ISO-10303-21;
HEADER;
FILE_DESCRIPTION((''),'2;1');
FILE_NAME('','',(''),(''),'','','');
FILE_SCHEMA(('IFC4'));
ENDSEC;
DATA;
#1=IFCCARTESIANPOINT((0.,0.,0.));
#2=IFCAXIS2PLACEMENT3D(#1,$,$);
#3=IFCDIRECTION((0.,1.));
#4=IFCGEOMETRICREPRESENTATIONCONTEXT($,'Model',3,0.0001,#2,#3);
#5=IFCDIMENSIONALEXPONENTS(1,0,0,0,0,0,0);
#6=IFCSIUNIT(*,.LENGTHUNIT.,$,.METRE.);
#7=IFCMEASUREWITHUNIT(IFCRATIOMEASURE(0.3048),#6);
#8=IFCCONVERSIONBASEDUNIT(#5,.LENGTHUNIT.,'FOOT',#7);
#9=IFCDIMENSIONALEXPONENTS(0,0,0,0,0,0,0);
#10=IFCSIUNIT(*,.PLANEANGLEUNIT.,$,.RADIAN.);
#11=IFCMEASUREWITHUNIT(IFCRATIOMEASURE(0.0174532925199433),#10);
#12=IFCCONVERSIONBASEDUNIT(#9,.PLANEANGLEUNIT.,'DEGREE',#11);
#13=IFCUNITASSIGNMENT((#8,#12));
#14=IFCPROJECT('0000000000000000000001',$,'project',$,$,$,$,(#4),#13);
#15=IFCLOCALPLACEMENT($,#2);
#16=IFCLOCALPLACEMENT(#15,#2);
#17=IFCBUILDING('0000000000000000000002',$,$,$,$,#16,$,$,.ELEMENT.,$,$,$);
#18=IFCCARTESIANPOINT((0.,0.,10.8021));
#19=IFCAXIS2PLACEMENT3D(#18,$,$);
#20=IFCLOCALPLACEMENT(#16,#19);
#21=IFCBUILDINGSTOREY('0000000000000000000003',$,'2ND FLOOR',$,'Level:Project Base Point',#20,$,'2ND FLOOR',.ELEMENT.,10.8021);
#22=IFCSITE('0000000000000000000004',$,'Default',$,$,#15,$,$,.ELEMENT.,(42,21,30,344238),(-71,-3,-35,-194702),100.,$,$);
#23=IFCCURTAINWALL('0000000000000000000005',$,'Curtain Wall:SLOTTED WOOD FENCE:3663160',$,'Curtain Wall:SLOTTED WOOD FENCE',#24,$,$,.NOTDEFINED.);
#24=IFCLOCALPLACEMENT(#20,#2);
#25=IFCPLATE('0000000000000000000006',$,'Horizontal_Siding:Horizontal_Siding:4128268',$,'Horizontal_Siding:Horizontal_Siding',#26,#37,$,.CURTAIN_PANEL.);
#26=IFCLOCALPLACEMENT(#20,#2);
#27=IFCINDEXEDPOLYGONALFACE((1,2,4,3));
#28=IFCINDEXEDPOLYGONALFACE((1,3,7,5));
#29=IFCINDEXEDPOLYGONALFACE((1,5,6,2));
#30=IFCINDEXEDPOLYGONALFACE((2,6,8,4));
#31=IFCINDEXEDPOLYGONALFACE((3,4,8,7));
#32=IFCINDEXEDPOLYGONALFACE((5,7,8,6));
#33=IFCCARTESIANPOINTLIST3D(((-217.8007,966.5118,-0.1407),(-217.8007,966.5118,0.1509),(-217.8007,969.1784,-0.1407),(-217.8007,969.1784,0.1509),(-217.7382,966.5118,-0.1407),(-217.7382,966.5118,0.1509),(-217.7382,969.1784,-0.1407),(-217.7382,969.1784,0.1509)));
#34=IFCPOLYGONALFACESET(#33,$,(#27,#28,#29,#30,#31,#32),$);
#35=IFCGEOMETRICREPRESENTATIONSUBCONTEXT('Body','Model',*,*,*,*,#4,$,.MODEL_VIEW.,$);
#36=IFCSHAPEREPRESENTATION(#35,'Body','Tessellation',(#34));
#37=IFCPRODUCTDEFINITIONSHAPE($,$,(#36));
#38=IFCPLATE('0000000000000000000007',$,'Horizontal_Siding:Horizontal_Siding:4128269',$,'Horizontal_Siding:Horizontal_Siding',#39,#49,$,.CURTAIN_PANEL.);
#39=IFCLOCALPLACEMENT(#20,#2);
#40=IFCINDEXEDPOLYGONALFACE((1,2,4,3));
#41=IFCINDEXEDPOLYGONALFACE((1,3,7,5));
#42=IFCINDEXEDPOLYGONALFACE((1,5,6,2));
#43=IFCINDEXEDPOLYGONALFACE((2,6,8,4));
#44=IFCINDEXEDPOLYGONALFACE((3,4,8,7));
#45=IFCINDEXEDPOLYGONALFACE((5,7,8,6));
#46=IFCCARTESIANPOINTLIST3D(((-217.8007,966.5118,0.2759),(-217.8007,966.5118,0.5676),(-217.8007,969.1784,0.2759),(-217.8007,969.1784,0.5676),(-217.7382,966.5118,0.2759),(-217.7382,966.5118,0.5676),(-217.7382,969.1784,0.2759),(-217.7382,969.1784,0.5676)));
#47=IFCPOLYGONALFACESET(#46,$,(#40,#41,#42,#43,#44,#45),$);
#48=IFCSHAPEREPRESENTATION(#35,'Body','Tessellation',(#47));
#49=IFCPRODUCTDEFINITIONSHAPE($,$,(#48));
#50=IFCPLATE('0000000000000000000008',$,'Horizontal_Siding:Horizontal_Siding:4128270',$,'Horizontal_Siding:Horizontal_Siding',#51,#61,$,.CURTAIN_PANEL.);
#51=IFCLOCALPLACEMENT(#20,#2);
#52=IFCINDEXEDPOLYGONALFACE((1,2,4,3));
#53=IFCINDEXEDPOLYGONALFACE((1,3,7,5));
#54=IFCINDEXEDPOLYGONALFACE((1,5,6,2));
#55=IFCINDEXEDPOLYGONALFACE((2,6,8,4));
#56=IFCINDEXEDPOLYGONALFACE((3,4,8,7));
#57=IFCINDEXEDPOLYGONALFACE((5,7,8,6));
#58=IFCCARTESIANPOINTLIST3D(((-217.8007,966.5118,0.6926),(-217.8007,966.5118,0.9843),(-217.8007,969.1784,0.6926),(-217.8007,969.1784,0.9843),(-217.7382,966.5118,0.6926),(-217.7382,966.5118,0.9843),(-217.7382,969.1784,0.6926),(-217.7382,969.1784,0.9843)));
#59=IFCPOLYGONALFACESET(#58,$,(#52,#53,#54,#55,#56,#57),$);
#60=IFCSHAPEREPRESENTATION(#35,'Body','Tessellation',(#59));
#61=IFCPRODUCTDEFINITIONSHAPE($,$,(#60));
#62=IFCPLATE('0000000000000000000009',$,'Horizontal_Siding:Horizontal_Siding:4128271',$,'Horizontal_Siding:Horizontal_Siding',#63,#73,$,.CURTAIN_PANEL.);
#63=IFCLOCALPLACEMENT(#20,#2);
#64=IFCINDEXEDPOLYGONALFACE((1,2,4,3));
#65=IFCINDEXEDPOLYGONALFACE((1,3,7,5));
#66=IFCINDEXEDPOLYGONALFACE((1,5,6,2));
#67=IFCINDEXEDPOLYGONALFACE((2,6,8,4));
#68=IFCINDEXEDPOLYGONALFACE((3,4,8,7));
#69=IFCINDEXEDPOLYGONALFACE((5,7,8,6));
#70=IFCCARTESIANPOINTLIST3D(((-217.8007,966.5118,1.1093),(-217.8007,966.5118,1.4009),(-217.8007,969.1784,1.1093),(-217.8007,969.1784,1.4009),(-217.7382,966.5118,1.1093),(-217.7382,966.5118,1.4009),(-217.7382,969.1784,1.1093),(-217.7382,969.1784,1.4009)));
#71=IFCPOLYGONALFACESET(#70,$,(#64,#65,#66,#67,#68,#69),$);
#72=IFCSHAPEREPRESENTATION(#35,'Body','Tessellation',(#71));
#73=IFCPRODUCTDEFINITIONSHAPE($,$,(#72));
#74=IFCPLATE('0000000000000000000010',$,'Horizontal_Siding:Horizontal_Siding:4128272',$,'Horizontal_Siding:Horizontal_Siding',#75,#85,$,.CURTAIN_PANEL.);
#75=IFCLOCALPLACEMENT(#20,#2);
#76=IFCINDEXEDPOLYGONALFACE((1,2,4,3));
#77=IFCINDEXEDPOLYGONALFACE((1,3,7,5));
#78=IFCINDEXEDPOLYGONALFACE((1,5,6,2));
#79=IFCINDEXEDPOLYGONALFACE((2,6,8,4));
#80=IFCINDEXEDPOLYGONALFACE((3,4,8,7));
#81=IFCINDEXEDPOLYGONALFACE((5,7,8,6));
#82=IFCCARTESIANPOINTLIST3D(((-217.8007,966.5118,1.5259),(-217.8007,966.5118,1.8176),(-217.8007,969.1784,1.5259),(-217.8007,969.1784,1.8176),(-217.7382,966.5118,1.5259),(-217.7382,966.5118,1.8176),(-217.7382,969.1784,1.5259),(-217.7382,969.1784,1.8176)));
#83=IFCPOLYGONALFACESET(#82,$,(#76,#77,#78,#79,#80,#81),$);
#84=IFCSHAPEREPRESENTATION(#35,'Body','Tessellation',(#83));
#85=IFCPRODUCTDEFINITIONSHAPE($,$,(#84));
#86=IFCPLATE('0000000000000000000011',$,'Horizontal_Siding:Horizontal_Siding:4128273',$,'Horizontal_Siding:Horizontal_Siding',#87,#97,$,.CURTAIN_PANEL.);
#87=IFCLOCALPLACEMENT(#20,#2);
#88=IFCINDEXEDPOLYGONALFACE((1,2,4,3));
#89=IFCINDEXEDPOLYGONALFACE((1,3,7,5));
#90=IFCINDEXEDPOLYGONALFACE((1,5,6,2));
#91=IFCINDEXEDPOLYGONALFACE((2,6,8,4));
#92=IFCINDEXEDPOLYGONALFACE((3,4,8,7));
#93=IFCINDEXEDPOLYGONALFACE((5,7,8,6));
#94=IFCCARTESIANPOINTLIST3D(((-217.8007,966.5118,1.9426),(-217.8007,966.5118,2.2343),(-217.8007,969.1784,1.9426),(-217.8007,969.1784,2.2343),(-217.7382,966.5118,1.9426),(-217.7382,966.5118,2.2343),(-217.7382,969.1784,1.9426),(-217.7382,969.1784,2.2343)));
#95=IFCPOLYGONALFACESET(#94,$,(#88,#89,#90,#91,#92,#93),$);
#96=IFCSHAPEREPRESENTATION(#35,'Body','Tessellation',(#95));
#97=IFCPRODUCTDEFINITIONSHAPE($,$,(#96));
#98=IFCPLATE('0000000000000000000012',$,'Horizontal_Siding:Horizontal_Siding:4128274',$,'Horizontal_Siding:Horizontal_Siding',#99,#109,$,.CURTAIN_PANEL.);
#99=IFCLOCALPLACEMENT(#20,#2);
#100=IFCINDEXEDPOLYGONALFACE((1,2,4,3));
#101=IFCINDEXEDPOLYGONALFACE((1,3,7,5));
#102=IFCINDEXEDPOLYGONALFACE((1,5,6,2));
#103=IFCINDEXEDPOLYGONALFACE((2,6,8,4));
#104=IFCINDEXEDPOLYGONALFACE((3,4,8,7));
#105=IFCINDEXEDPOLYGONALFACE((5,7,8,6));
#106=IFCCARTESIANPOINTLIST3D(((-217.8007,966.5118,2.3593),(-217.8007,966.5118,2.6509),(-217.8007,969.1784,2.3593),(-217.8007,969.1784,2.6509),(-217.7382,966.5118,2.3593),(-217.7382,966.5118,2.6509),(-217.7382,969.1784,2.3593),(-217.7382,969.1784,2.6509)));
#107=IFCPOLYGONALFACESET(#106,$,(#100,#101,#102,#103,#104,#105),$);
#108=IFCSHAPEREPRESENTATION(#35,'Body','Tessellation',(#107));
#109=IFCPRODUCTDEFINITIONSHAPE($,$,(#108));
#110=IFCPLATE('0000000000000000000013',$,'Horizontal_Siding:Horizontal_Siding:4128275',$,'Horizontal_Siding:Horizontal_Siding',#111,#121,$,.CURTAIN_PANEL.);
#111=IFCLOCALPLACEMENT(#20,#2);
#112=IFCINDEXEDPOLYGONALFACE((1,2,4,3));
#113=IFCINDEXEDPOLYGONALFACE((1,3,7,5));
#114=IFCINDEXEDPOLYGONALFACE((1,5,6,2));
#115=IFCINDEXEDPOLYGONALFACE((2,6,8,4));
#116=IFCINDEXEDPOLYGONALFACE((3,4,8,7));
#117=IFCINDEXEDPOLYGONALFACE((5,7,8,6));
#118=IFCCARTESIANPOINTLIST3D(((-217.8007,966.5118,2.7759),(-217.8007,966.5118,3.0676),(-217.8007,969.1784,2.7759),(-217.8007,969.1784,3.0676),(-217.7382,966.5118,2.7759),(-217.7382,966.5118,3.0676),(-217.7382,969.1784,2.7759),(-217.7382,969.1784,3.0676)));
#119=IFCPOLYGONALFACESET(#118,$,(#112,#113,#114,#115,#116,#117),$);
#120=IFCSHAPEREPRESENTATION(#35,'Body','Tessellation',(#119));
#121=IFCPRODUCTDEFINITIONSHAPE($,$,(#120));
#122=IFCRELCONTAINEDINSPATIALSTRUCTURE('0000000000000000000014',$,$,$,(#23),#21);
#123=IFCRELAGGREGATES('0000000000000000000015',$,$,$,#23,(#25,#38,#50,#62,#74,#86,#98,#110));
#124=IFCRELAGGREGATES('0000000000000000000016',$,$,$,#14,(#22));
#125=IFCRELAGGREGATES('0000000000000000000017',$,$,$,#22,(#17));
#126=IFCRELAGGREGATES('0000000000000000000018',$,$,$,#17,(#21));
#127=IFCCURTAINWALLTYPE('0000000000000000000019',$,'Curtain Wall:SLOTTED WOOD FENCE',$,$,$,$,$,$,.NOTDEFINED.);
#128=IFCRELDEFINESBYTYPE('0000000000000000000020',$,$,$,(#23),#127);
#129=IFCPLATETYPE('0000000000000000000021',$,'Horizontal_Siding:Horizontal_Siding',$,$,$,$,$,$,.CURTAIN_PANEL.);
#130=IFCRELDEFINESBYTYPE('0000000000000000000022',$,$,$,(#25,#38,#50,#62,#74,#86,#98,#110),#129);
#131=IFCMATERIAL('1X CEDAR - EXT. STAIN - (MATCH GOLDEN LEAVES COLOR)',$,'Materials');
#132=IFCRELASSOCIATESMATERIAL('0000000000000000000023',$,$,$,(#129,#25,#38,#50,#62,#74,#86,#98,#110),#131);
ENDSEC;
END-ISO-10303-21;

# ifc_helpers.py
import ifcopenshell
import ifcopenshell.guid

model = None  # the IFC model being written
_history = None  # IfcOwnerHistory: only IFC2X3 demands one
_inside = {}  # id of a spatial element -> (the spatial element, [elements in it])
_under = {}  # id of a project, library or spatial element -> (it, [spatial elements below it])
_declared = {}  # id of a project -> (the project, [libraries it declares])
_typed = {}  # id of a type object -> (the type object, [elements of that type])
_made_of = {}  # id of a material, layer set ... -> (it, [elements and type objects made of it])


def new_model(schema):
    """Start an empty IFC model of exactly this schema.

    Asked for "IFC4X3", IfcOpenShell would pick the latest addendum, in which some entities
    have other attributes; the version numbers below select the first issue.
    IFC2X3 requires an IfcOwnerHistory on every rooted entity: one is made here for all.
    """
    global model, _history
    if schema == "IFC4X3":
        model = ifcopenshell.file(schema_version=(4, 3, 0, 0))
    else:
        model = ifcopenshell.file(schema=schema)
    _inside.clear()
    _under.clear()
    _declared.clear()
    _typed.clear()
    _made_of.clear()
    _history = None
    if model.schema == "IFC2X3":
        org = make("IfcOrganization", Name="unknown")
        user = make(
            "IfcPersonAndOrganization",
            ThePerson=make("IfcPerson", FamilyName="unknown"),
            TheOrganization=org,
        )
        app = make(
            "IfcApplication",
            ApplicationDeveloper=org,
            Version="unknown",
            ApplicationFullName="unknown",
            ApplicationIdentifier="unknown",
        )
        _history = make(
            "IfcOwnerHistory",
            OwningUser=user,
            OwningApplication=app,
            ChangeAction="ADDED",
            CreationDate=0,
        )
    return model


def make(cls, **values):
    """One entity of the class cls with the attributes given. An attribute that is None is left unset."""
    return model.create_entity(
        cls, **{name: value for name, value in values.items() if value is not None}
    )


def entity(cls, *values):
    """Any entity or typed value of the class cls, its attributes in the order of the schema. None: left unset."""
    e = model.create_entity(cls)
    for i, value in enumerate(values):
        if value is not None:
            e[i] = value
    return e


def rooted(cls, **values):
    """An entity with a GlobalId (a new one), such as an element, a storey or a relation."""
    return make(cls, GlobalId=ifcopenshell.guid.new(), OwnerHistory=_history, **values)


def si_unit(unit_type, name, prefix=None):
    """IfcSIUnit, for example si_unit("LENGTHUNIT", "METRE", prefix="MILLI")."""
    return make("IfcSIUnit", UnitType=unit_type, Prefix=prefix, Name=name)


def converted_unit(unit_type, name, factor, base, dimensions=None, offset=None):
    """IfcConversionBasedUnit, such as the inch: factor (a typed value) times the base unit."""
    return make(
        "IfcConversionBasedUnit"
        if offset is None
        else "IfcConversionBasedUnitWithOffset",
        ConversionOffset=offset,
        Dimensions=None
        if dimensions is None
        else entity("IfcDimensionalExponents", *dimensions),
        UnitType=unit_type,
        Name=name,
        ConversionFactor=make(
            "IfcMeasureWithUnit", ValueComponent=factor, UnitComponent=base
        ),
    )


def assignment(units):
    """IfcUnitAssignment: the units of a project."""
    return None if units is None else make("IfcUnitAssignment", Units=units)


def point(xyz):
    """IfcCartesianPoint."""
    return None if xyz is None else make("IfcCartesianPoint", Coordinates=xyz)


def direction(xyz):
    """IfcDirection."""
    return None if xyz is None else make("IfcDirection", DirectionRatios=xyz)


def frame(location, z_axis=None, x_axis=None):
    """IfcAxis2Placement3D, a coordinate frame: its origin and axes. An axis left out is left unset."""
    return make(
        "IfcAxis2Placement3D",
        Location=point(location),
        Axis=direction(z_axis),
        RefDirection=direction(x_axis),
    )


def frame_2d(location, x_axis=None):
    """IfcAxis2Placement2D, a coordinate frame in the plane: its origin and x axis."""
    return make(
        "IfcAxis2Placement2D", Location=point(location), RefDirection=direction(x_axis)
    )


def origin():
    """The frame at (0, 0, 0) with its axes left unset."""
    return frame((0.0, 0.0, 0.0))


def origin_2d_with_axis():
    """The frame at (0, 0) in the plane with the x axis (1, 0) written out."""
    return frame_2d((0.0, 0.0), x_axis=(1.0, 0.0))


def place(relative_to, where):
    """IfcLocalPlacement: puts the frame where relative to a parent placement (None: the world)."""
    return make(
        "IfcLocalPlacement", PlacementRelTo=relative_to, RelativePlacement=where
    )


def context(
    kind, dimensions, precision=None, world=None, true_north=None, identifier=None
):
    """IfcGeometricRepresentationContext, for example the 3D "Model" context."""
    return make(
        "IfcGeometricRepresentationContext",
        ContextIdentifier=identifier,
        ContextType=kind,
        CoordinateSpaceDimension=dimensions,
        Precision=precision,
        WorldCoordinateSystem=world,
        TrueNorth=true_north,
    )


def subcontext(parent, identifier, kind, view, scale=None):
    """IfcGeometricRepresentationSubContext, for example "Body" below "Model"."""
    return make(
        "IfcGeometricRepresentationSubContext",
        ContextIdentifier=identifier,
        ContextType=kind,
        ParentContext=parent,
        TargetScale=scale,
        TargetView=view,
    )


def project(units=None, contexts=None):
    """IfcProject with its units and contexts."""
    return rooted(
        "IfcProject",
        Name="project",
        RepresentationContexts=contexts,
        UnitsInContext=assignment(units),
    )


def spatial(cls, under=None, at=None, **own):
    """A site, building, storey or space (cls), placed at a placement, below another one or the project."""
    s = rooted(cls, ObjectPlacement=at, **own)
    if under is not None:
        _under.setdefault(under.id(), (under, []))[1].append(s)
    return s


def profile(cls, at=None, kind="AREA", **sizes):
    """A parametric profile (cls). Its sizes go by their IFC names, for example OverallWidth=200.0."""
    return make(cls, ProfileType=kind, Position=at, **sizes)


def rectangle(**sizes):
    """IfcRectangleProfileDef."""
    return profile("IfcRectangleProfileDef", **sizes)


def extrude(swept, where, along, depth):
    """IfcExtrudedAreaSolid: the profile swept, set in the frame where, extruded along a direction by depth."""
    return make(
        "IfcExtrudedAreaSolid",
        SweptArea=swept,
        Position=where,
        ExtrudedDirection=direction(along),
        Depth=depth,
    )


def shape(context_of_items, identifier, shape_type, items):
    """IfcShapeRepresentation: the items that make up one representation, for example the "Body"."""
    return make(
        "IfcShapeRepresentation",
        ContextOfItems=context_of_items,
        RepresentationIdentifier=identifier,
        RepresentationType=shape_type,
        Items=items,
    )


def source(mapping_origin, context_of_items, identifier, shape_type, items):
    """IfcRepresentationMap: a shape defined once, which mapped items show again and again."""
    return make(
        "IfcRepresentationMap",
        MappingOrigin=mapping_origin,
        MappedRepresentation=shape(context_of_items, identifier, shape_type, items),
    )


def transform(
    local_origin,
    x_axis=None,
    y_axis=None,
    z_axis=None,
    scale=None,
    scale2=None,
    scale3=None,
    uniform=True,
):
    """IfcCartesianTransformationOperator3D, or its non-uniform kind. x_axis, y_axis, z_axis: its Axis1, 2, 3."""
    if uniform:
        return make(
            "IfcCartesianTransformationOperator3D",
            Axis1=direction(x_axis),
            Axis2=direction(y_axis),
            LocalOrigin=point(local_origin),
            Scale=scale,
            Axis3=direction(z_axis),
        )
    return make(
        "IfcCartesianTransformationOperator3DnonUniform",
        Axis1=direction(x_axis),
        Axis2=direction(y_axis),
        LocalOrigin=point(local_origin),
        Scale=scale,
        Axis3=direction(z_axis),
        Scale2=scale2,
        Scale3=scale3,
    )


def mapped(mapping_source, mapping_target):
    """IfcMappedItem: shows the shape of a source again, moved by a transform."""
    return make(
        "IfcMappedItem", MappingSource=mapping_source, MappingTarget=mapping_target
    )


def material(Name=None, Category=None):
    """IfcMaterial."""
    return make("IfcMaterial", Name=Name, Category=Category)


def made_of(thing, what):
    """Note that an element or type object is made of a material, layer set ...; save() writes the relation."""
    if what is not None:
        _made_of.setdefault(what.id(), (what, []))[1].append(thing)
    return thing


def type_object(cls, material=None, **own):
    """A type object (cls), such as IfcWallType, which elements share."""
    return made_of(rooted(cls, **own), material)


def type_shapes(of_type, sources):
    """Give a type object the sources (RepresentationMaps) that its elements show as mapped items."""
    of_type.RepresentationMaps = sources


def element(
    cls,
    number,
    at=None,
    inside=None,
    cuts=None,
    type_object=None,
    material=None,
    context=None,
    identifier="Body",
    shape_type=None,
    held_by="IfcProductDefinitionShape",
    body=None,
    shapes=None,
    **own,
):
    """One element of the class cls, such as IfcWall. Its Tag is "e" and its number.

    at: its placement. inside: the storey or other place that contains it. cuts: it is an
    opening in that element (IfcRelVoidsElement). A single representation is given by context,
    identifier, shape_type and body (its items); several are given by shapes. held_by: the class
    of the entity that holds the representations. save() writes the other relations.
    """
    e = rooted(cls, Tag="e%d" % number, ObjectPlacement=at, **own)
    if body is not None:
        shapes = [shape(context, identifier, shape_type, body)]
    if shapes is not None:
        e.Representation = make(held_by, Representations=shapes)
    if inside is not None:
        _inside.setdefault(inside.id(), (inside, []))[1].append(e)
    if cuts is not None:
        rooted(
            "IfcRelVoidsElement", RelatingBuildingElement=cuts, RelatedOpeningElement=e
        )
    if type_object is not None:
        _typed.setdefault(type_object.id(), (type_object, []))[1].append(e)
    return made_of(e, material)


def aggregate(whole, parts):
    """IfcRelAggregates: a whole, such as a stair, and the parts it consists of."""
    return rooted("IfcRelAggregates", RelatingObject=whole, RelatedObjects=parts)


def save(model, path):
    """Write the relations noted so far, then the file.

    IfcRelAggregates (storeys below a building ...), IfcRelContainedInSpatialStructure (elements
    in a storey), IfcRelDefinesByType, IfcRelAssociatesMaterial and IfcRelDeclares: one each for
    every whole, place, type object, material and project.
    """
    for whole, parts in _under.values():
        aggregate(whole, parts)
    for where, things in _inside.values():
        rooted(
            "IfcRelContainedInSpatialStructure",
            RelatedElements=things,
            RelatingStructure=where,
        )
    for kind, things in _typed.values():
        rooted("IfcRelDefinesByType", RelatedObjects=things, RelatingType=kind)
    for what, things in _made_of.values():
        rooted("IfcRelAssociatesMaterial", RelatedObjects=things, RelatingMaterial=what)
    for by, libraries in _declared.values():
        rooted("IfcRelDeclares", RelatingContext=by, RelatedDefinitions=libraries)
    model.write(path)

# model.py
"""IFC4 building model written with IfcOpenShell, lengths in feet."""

from ifc_helpers import new_model, entity, si_unit, converted_unit, direction, frame, origin, origin_2d_with_axis, place, context, subcontext, project, spatial, rectangle, extrude, source, transform, mapped, material, type_object, type_shapes, element, aggregate, save


model = new_model("IFC4")

# Units and contexts
model_context = context("Model", 3, precision=0.0001, world=origin(), true_north=direction((0.0, 1.0)))
body_context = subcontext(model_context, "Body", "Model", "MODEL_VIEW")
ifc_project = project(units=[converted_unit("LENGTHUNIT", "FOOT", entity("IfcRatioMeasure", 0.3048), si_unit("LENGTHUNIT", "METRE"), dimensions=[1, 0, 0, 0, 0, 0, 0]), converted_unit("PLANEANGLEUNIT", "DEGREE", entity("IfcRatioMeasure", 0.0174532925199433), si_unit("PLANEANGLEUNIT", "RADIAN"), dimensions=[0, 0, 0, 0, 0, 0, 0])], contexts=[model_context])

# Site, building, storey
site_placement = place(None, origin())
site = spatial("IfcSite", under=ifc_project, at=site_placement, Name="Default", CompositionType="ELEMENT", RefLatitude=(42, 21, 30, 344238), RefLongitude=(-71, -3, -35, -194702), RefElevation=100.0)
building_placement = place(site_placement, origin())
building = spatial("IfcBuilding", under=site, at=building_placement, CompositionType="ELEMENT")
storey_placement = place(building_placement, frame((0.0, 0.0, 10.8021)))
storey = spatial("IfcBuildingStorey", under=building, at=storey_placement, Name="2ND FLOOR", ObjectType="Level:Project Base Point", LongName="2ND FLOOR", CompositionType="ELEMENT", Elevation=10.8021)

# Curtain wall, plates
curtain_wall_type = type_object("IfcCurtainWallType", Name="Curtain Wall:SLOTTED WOOD FENCE", PredefinedType="NOTDEFINED")
curtain_wall_placement = place(storey_placement, frame((0.0, 0.0, -10.8021)))
curtain_wall = element("IfcCurtainWall", 1, at=curtain_wall_placement, inside=storey, type_object=curtain_wall_type, Name="Curtain Wall:SLOTTED WOOD FENCE:3663160", ObjectType="Curtain Wall:SLOTTED WOOD FENCE", PredefinedType="NOTDEFINED")
ifc_material_1 = material(Name="1X CEDAR - EXT. STAIN - (MATCH GOLDEN LEAVES COLOR)", Category="Materials")
plate_type = type_object("IfcPlateType", Name="Horizontal_Siding:Horizontal_Siding", PredefinedType="CURTAIN_PANEL", material=ifc_material_1)
shared_shape_1 = source(origin(), body_context, "Body", "SweptSolid", [
    extrude(rectangle(XDim=2.6667, YDim=0.0625, at=origin_2d_with_axis()), frame((1.3333, 0.0312, 0.0), z_axis=(0.0, 0.0, 1.0), x_axis=(-1.0, 0.0, 0.0)), (0.0, 0.0, 1.0), 0.2917),
])
type_shapes(plate_type, [shared_shape_1])
plate_1_placement = place(curtain_wall_placement, frame((-217.8007, 969.1784, 10.6613), z_axis=(0.0, 0.0, 1.0), x_axis=(0.0, -1.0, 0.0)))
plate_1 = element("IfcPlate", 2, at=plate_1_placement, type_object=plate_type, material=ifc_material_1, Name="Horizontal_Siding:Horizontal_Siding:4128268", ObjectType="Horizontal_Siding:Horizontal_Siding", PredefinedType="CURTAIN_PANEL", context=body_context, shape_type="MappedRepresentation", body=[
    mapped(shared_shape_1, transform((0.0, 0.0, 0.0), scale=1.0)),
])
plate_2_placement = place(curtain_wall_placement, frame((-217.8007, 969.1784, 11.078), z_axis=(0.0, 0.0, 1.0), x_axis=(0.0, -1.0, 0.0)))
plate_2 = element("IfcPlate", 3, at=plate_2_placement, type_object=plate_type, material=ifc_material_1, Name="Horizontal_Siding:Horizontal_Siding:4128269", ObjectType="Horizontal_Siding:Horizontal_Siding", PredefinedType="CURTAIN_PANEL", context=body_context, shape_type="MappedRepresentation", body=[
    mapped(shared_shape_1, transform((0.0, 0.0, 0.0), scale=1.0)),
])
plate_3_placement = place(curtain_wall_placement, frame((-217.8007, 969.1784, 11.4947), z_axis=(0.0, 0.0, 1.0), x_axis=(0.0, -1.0, 0.0)))
plate_3 = element("IfcPlate", 4, at=plate_3_placement, type_object=plate_type, material=ifc_material_1, Name="Horizontal_Siding:Horizontal_Siding:4128270", ObjectType="Horizontal_Siding:Horizontal_Siding", PredefinedType="CURTAIN_PANEL", context=body_context, shape_type="MappedRepresentation", body=[
    mapped(shared_shape_1, transform((0.0, 0.0, 0.0), scale=1.0)),
])
plate_4_placement = place(curtain_wall_placement, frame((-217.8007, 969.1784, 11.9113), z_axis=(0.0, 0.0, 1.0), x_axis=(0.0, -1.0, 0.0)))
plate_4 = element("IfcPlate", 5, at=plate_4_placement, type_object=plate_type, material=ifc_material_1, Name="Horizontal_Siding:Horizontal_Siding:4128271", ObjectType="Horizontal_Siding:Horizontal_Siding", PredefinedType="CURTAIN_PANEL", context=body_context, shape_type="MappedRepresentation", body=[
    mapped(shared_shape_1, transform((0.0, 0.0, 0.0), scale=1.0)),
])
plate_5_placement = place(curtain_wall_placement, frame((-217.8007, 969.1784, 12.328), z_axis=(0.0, 0.0, 1.0), x_axis=(0.0, -1.0, 0.0)))
plate_5 = element("IfcPlate", 6, at=plate_5_placement, type_object=plate_type, material=ifc_material_1, Name="Horizontal_Siding:Horizontal_Siding:4128272", ObjectType="Horizontal_Siding:Horizontal_Siding", PredefinedType="CURTAIN_PANEL", context=body_context, shape_type="MappedRepresentation", body=[
    mapped(shared_shape_1, transform((0.0, 0.0, 0.0), scale=1.0)),
])
plate_6_placement = place(curtain_wall_placement, frame((-217.8007, 969.1784, 12.7447), z_axis=(0.0, 0.0, 1.0), x_axis=(0.0, -1.0, 0.0)))
plate_6 = element("IfcPlate", 7, at=plate_6_placement, type_object=plate_type, material=ifc_material_1, Name="Horizontal_Siding:Horizontal_Siding:4128273", ObjectType="Horizontal_Siding:Horizontal_Siding", PredefinedType="CURTAIN_PANEL", context=body_context, shape_type="MappedRepresentation", body=[
    mapped(shared_shape_1, transform((0.0, 0.0, 0.0), scale=1.0)),
])
plate_7_placement = place(curtain_wall_placement, frame((-217.8007, 969.1784, 13.1613), z_axis=(0.0, 0.0, 1.0), x_axis=(0.0, -1.0, 0.0)))
plate_7 = element("IfcPlate", 8, at=plate_7_placement, type_object=plate_type, material=ifc_material_1, Name="Horizontal_Siding:Horizontal_Siding:4128274", ObjectType="Horizontal_Siding:Horizontal_Siding", PredefinedType="CURTAIN_PANEL", context=body_context, shape_type="MappedRepresentation", body=[
    mapped(shared_shape_1, transform((0.0, 0.0, 0.0), scale=1.0)),
])
plate_8_placement = place(curtain_wall_placement, frame((-217.8007, 969.1784, 13.578), z_axis=(0.0, 0.0, 1.0), x_axis=(0.0, -1.0, 0.0)))
plate_8 = element("IfcPlate", 9, at=plate_8_placement, type_object=plate_type, material=ifc_material_1, Name="Horizontal_Siding:Horizontal_Siding:4128275", ObjectType="Horizontal_Siding:Horizontal_Siding", PredefinedType="CURTAIN_PANEL", context=body_context, shape_type="MappedRepresentation", body=[
    mapped(shared_shape_1, transform((0.0, 0.0, 0.0), scale=1.0)),
])
aggregate(curtain_wall, [plate_1, plate_2, plate_3, plate_4, plate_5, plate_6, plate_7, plate_8])

save(model, "model.ifc")
